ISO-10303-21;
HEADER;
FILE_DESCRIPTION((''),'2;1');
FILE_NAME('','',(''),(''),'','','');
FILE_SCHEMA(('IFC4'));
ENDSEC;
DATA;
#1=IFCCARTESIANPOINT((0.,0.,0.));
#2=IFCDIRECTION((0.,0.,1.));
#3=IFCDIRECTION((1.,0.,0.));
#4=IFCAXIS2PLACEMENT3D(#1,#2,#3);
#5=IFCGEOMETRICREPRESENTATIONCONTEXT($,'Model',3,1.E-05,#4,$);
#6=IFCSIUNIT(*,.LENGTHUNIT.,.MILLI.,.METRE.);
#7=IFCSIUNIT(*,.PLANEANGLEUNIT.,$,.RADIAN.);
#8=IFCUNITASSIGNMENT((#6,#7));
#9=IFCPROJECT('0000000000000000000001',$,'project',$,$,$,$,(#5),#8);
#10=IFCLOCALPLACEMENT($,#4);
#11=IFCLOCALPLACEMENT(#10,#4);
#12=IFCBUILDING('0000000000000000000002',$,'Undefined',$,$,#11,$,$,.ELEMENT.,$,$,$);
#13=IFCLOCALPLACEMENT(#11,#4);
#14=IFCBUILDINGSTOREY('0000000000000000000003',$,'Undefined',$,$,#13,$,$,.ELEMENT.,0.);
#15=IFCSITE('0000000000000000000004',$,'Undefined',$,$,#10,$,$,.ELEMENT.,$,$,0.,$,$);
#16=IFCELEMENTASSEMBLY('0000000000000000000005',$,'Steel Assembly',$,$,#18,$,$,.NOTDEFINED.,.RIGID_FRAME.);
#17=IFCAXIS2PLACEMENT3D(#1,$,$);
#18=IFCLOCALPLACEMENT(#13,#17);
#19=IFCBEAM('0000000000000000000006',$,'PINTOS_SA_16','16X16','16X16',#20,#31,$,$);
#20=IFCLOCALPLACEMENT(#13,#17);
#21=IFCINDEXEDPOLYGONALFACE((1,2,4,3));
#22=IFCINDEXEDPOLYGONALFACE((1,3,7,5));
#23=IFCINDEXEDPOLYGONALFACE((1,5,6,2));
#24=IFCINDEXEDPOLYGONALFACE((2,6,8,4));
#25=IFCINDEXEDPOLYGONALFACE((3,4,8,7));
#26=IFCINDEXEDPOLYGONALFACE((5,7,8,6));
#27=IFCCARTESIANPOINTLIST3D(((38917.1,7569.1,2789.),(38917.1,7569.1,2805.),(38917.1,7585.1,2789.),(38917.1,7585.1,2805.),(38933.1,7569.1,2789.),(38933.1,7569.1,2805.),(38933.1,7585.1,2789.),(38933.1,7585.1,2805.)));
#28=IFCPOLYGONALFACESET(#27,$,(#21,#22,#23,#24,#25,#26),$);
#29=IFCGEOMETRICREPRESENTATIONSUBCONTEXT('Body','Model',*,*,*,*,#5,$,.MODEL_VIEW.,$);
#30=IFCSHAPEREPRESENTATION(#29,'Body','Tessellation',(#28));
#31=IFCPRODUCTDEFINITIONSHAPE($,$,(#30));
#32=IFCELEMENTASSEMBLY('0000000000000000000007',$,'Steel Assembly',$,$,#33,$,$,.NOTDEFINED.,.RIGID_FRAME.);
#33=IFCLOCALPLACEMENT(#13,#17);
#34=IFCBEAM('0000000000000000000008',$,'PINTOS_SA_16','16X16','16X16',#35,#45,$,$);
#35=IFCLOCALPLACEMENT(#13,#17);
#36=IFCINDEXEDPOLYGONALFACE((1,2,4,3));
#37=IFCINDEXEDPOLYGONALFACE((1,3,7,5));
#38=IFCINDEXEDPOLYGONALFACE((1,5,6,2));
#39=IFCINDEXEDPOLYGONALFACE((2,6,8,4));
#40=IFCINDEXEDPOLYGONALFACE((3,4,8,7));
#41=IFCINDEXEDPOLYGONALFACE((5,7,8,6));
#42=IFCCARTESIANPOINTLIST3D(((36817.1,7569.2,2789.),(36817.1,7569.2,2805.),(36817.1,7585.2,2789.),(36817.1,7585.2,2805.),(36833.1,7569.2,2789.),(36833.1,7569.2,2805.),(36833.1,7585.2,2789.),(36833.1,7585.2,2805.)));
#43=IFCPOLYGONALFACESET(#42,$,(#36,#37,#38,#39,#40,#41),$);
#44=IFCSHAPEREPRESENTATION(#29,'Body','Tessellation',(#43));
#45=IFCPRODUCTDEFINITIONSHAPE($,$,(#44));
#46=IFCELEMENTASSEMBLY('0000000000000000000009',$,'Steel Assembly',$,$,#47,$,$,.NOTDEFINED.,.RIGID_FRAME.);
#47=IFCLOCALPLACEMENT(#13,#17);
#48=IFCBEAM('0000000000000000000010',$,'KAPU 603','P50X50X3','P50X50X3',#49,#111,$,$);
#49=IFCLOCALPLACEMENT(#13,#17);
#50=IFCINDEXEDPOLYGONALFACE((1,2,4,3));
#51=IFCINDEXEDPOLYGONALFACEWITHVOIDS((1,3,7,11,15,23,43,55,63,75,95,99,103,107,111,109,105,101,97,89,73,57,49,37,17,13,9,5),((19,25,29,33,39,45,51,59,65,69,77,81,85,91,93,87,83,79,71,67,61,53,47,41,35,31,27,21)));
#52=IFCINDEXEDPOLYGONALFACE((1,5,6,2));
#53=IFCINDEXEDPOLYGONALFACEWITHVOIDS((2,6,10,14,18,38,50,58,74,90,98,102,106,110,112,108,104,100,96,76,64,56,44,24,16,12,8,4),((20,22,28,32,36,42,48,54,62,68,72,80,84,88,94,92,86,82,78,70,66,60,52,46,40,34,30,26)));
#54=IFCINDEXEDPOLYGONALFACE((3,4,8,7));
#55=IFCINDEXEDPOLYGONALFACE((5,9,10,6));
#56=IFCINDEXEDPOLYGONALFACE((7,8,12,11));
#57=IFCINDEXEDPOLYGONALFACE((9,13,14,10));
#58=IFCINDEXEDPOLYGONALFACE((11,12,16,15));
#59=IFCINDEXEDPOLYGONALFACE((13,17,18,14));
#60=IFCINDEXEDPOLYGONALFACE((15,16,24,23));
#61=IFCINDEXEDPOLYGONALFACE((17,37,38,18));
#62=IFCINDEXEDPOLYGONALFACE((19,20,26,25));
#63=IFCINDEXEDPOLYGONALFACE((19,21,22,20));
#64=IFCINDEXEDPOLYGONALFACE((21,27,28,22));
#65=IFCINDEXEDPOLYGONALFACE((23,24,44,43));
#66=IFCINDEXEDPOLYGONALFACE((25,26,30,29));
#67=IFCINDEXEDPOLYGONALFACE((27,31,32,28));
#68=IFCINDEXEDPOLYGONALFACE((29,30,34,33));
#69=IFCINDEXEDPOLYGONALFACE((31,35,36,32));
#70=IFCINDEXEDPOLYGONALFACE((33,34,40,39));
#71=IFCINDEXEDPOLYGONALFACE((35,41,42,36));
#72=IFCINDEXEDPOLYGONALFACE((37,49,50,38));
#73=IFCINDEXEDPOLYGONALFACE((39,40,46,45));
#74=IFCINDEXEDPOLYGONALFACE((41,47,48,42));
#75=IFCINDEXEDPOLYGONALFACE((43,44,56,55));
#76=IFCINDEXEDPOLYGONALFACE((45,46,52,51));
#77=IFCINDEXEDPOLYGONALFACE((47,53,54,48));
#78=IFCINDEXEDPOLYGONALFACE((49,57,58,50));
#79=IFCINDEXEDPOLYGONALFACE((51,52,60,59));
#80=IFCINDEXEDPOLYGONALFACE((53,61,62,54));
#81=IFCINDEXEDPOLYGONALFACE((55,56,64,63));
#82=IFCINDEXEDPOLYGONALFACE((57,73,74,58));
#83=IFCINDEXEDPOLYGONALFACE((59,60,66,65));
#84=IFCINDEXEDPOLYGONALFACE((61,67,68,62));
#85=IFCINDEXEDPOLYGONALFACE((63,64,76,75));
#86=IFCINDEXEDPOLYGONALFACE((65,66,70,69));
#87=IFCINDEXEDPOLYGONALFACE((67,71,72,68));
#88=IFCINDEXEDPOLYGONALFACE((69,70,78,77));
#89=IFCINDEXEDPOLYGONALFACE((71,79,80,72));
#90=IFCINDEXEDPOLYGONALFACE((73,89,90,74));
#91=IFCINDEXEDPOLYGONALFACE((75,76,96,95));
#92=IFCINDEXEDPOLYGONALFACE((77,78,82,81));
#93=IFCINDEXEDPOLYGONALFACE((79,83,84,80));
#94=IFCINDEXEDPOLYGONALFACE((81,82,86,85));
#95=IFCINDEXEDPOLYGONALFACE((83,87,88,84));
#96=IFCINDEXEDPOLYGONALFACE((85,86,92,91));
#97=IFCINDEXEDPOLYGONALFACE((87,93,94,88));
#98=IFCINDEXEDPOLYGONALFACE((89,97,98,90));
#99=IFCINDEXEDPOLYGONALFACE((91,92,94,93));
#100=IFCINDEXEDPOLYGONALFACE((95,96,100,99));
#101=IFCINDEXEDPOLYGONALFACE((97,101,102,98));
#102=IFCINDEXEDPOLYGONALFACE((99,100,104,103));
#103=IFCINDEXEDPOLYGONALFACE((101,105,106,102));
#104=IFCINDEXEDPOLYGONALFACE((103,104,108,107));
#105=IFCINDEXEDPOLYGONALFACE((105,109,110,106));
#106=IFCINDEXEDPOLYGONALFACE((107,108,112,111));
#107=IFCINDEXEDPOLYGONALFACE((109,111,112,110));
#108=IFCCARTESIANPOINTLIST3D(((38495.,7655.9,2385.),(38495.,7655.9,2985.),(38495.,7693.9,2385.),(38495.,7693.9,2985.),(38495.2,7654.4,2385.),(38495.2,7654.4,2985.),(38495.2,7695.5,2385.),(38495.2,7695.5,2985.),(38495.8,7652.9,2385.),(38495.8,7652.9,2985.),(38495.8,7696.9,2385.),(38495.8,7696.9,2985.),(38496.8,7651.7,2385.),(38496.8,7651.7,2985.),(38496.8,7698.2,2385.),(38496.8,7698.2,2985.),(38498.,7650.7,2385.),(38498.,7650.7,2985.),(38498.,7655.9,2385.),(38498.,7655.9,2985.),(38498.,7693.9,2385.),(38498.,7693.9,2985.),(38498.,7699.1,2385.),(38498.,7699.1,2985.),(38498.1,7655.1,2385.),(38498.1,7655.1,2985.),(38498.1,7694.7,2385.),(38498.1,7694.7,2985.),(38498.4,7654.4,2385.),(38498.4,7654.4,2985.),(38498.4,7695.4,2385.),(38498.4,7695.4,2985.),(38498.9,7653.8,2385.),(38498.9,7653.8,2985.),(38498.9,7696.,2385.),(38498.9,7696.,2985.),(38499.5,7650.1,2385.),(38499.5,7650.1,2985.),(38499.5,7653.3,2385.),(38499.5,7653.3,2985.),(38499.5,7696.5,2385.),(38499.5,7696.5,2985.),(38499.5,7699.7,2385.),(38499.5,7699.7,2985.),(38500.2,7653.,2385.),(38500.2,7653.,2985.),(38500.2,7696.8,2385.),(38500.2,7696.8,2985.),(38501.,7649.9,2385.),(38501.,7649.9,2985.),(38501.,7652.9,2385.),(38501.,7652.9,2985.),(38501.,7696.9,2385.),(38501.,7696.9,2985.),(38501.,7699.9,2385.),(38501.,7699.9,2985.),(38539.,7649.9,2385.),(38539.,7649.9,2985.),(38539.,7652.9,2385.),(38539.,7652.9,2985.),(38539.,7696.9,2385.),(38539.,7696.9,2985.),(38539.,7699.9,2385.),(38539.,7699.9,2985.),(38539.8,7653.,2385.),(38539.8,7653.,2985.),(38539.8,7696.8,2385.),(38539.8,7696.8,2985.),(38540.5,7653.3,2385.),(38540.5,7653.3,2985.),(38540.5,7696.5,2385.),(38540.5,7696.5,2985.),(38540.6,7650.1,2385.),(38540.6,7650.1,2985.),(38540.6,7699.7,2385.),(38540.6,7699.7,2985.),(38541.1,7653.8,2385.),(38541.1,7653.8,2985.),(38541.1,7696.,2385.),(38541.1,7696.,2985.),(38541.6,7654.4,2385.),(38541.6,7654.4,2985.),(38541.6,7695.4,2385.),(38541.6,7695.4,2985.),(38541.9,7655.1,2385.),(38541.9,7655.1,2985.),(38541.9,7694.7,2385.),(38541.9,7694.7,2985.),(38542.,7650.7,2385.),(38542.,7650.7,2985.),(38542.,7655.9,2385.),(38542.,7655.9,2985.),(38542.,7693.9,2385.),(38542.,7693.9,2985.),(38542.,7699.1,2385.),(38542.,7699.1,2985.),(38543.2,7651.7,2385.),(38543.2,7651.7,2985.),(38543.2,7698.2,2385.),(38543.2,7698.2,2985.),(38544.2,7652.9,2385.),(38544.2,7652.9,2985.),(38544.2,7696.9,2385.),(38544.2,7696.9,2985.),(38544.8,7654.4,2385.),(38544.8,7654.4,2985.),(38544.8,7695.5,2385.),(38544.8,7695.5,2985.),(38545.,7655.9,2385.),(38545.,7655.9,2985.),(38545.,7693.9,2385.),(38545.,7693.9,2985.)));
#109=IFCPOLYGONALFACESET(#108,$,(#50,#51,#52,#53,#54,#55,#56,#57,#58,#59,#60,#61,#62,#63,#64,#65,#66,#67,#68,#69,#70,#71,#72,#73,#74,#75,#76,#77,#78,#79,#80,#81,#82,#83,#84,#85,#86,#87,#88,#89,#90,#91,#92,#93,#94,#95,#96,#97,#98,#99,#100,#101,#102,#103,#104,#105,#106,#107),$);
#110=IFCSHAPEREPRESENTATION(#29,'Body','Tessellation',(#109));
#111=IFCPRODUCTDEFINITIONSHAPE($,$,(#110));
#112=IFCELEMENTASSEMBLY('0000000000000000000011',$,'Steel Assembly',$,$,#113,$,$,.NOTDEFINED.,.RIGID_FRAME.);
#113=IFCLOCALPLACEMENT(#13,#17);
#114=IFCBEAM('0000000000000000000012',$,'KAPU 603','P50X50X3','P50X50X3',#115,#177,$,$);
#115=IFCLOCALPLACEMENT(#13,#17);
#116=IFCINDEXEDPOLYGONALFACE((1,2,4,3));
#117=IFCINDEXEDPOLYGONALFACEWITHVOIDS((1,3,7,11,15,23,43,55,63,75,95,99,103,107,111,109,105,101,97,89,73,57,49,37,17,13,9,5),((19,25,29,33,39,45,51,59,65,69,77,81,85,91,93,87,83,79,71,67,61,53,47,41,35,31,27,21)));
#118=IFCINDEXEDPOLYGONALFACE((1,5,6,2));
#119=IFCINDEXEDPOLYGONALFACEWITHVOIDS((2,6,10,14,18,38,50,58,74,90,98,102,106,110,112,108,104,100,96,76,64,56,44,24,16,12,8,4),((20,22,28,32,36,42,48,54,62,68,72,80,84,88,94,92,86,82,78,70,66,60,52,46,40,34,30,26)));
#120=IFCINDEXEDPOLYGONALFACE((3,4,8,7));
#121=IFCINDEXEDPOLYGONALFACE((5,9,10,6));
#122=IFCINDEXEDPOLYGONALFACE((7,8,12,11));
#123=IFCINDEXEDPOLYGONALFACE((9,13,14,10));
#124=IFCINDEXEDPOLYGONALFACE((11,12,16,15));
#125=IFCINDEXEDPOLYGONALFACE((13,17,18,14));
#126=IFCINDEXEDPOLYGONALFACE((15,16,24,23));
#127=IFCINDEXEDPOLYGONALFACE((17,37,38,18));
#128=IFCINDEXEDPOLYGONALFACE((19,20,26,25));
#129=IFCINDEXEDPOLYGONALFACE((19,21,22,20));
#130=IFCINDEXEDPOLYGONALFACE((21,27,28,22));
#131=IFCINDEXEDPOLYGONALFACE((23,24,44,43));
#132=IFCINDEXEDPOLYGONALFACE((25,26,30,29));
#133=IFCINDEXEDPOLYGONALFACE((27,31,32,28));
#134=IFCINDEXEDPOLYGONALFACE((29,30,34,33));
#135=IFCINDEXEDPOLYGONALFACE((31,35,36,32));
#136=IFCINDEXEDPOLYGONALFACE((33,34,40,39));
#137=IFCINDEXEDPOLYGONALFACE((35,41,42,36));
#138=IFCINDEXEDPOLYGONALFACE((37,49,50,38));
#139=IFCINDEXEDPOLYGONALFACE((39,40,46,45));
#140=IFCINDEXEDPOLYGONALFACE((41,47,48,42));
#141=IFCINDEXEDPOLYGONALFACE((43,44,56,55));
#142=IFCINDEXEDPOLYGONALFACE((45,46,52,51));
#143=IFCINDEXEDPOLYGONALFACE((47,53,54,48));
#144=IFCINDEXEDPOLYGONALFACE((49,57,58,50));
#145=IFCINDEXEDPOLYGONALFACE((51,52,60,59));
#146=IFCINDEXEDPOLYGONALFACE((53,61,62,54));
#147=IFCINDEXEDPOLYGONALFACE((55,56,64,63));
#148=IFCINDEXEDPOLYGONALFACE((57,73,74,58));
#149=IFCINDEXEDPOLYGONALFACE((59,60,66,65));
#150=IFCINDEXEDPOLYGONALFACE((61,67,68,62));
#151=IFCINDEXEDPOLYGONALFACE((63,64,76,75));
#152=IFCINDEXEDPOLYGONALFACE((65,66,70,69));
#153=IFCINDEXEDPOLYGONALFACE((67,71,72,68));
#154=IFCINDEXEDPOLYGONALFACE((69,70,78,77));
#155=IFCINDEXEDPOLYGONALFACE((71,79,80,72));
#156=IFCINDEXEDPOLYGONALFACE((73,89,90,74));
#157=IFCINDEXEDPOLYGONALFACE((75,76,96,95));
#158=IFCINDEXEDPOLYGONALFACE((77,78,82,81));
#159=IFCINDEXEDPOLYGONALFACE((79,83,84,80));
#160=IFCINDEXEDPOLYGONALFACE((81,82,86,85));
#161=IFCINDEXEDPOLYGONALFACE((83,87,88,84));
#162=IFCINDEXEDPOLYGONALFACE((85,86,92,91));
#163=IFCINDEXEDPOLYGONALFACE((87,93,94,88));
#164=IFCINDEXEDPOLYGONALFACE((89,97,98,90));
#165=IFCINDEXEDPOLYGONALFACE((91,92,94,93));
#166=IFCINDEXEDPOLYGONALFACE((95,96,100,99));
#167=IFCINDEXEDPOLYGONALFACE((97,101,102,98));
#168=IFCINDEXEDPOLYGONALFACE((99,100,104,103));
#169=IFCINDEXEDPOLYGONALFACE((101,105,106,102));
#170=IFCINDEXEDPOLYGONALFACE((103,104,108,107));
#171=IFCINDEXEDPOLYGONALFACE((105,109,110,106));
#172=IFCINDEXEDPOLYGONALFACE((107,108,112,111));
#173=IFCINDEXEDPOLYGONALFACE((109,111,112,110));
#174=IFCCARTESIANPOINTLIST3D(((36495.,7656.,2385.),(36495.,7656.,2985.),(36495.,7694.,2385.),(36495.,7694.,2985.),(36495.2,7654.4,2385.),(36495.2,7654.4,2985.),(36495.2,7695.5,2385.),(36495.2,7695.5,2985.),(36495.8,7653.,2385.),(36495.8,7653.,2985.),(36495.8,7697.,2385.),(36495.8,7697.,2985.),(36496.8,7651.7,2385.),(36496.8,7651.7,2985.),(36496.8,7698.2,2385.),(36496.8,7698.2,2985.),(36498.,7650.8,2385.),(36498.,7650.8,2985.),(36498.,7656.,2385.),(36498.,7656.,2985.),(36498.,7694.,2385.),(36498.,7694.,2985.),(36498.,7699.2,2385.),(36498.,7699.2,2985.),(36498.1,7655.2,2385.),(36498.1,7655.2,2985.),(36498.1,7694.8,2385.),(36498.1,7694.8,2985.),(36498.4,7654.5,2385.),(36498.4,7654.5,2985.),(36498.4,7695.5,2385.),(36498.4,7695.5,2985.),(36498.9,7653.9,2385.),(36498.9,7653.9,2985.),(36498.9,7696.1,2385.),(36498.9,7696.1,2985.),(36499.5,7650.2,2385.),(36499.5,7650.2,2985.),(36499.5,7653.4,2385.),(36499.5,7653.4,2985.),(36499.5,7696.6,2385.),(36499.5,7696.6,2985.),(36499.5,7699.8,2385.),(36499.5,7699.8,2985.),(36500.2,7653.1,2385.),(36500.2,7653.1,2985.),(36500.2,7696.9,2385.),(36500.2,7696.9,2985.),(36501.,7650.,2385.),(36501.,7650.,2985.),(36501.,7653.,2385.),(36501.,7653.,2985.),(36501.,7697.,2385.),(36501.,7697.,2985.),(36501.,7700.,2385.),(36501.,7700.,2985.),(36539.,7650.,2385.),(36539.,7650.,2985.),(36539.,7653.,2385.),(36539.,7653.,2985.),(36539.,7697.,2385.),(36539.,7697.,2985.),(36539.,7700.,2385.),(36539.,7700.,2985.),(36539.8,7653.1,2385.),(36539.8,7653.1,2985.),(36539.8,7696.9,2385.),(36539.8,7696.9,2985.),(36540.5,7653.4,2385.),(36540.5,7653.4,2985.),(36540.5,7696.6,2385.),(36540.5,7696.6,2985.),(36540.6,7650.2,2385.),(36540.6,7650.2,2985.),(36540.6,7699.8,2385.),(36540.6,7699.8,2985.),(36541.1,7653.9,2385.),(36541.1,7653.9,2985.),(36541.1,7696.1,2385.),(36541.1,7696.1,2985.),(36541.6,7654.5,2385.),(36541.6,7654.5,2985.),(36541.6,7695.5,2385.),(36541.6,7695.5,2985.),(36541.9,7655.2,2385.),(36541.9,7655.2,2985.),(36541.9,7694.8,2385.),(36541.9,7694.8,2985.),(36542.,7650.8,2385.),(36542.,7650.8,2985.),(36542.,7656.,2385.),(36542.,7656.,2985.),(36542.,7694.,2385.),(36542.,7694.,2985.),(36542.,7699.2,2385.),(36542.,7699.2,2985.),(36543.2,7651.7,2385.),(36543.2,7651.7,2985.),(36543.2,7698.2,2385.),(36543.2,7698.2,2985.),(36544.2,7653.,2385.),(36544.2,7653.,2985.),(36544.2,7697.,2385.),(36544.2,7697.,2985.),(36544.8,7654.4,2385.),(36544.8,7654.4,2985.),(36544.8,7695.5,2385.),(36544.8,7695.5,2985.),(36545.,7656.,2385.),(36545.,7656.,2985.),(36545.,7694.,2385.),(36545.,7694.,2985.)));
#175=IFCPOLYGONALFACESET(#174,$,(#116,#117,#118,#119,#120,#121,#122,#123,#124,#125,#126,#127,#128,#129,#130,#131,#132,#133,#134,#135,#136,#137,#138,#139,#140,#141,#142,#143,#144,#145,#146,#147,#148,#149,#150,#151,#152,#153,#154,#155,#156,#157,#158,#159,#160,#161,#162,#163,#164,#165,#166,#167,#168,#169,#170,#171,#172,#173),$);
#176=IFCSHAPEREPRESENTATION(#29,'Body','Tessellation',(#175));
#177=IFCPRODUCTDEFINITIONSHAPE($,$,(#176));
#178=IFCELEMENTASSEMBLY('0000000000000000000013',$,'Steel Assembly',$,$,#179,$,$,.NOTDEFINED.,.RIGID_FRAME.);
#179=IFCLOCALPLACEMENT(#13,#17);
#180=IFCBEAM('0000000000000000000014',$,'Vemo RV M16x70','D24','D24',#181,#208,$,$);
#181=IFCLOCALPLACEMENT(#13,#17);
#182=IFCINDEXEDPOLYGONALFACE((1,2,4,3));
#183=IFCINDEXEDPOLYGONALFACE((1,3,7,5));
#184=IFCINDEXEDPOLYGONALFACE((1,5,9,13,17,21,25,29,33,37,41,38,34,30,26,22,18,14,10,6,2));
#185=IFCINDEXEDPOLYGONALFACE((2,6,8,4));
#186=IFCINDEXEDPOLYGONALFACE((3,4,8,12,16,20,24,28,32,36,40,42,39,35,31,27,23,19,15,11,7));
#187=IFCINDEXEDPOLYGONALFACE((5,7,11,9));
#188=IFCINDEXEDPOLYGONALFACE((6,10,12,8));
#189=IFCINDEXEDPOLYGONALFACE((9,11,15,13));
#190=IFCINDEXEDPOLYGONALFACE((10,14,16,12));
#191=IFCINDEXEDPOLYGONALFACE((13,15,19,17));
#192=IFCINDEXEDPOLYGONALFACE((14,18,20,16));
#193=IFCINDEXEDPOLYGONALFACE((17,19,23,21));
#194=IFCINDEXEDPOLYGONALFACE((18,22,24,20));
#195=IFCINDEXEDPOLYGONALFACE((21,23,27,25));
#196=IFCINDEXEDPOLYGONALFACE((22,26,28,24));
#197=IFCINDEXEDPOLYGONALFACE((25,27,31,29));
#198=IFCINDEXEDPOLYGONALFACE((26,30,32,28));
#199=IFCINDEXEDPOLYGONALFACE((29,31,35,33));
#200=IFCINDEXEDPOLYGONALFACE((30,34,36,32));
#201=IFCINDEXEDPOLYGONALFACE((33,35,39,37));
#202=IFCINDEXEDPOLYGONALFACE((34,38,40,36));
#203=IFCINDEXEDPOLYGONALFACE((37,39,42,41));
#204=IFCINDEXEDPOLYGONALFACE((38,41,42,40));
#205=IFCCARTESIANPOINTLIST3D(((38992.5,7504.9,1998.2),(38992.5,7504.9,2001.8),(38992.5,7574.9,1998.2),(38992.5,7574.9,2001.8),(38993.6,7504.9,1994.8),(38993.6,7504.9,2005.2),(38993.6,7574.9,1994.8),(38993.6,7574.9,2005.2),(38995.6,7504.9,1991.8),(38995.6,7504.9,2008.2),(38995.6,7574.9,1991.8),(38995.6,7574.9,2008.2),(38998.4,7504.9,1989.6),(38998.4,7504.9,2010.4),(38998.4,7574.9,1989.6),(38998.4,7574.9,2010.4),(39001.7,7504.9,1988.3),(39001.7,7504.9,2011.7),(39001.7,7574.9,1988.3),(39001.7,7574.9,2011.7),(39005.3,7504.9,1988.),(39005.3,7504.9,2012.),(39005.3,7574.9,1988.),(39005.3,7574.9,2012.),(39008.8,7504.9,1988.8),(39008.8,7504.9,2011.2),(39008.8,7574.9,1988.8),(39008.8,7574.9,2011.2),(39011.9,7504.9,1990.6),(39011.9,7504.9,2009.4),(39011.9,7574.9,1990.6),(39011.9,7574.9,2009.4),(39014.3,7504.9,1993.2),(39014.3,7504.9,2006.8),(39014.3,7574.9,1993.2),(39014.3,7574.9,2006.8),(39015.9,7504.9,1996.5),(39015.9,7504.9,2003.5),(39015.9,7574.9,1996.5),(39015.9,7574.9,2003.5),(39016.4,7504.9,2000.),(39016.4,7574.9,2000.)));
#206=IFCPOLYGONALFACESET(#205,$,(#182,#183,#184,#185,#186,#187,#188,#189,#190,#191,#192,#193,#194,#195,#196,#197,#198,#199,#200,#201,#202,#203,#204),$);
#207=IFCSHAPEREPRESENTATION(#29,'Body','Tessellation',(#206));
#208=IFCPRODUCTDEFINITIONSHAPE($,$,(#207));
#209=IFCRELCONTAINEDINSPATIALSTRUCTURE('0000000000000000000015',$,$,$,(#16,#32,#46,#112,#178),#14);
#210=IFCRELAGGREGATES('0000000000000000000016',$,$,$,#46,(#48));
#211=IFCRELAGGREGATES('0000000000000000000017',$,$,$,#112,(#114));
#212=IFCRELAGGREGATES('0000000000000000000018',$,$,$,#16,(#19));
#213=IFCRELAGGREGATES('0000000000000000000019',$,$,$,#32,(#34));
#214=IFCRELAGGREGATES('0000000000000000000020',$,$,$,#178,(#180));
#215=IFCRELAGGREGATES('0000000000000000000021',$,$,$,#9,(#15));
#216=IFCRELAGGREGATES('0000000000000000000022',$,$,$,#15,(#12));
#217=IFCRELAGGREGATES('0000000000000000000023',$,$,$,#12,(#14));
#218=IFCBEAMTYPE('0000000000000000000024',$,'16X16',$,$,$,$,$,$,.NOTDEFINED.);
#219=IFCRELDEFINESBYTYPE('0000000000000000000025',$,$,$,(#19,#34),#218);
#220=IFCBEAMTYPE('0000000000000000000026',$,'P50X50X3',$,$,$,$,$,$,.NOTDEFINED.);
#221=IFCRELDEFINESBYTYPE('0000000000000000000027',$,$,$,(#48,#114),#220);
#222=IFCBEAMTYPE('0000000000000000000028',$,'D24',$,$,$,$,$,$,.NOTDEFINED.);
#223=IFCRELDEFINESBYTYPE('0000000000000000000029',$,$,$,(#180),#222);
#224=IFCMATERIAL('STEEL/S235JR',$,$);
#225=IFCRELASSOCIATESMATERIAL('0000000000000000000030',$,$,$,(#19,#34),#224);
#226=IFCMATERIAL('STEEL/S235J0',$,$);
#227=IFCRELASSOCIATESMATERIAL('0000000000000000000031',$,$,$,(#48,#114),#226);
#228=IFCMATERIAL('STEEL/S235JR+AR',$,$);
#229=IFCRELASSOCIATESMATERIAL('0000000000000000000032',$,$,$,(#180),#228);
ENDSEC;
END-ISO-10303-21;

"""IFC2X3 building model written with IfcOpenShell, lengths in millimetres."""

from ifc_helpers import new_model, si_unit, frame, origin_with_axes, origin_2d_with_axis, place, context, subcontext, project, spatial, rectangle, hollow_rectangle, circle, extrude, material, type_object, element, aggregate, save


model = new_model("IFC2X3")

# Units and contexts
model_context = context("Model", 3, precision=1e-05, world=origin_with_axes())
body_context = subcontext(model_context, "Body", "Model", "MODEL_VIEW")
ifc_project = project(units=[si_unit("LENGTHUNIT", "METRE", prefix="MILLI"), si_unit("PLANEANGLEUNIT", "RADIAN")], contexts=[model_context])

# Site, building, storey
site_placement = place(None, origin_with_axes())
site = spatial("IfcSite", under=ifc_project, at=site_placement, Name="Undefined", CompositionType="ELEMENT", RefElevation=0.0)
building_placement = place(site_placement, origin_with_axes())
building = spatial("IfcBuilding", under=site, at=building_placement, Name="Undefined", CompositionType="ELEMENT")
storey_placement = place(building_placement, origin_with_axes())
storey = spatial("IfcBuildingStorey", under=building, at=storey_placement, Name="Undefined", CompositionType="ELEMENT", Elevation=0.0)

# Element assemblies, beams
assembly_1_placement = place(storey_placement, origin_with_axes())
assembly_1 = element("IfcElementAssembly", 1, at=assembly_1_placement, inside=storey, Name="Steel Assembly", AssemblyPlace="NOTDEFINED", PredefinedType="RIGID_FRAME")
ifc_material_1 = material(Name="STEEL/S235JR")
beam_type_1 = type_object("IfcBeamType", Name="16X16", PredefinedType="NOTDEFINED")
beam_1_placement = place(assembly_1_placement, frame((38933.1, 7577.1, 2797.0), z_axis=(0.0, 0.0, 1.0), x_axis=(-1.0, 0.00003, 0.0)))
beam_1 = element("IfcBeam", 2, at=beam_1_placement, type_object=beam_type_1, material=ifc_material_1, Name="PINTOS_SA_16", Description="16X16", ObjectType="16X16", context=body_context, shape_type="SweptSolid", body=[
    extrude(rectangle(XDim=16.0, YDim=16.0, at=origin_2d_with_axis()), frame((16.0, 0.0, 0.0), z_axis=(-1.0, 0.0, 0.0), x_axis=(0.0, -1.0, 0.0)), (0.0, 0.0, 1.0), 16.0),
])
assembly_2_placement = place(storey_placement, origin_with_axes())
assembly_2 = element("IfcElementAssembly", 3, at=assembly_2_placement, inside=storey, Name="Steel Assembly", AssemblyPlace="NOTDEFINED", PredefinedType="RIGID_FRAME")
beam_2_placement = place(assembly_2_placement, frame((36817.1, 7577.2, 2797.0), z_axis=(0.0, 0.0, 1.0), x_axis=(1.0, -0.00003, 0.0)))
beam_2 = element("IfcBeam", 4, at=beam_2_placement, type_object=beam_type_1, material=ifc_material_1, Name="PINTOS_SA_16", Description="16X16", ObjectType="16X16", context=body_context, shape_type="SweptSolid", body=[
    extrude(rectangle(XDim=16.0, YDim=16.0, at=origin_2d_with_axis()), frame((16.0, 0.0, 0.0), z_axis=(-1.0, 0.0, 0.0), x_axis=(0.0, -1.0, 0.0)), (0.0, 0.0, 1.0), 16.0),
])
assembly_3_placement = place(storey_placement, origin_with_axes())
assembly_3 = element("IfcElementAssembly", 5, at=assembly_3_placement, inside=storey, Name="Steel Assembly", AssemblyPlace="NOTDEFINED", PredefinedType="RIGID_FRAME")
ifc_material_2 = material(Name="STEEL/S235J0")
beam_type_2 = type_object("IfcBeamType", Name="P50X50X3", PredefinedType="NOTDEFINED")
beam_3_placement = place(assembly_3_placement, frame((38520.0, 7674.9, 2985.0), z_axis=(1.0, -0.00003, 0.0), x_axis=(0.0, 0.0, -1.0)))
beam_3 = element("IfcBeam", 6, at=beam_3_placement, type_object=beam_type_2, material=ifc_material_2, Name="KAPU 603", Description="P50X50X3", ObjectType="P50X50X3", context=body_context, shape_type="SweptSolid", body=[
    extrude(hollow_rectangle(XDim=50.0, YDim=50.0, WallThickness=3.0, InnerFilletRadius=3.0, OuterFilletRadius=6.0, at=origin_2d_with_axis()), frame((600.0, 0.0, 0.0), z_axis=(-1.0, 0.0, 0.0), x_axis=(0.0, -1.0, 0.0)), (0.0, 0.0, 1.0), 600.0),
])
aggregate(assembly_3, [beam_3])
assembly_4_placement = place(storey_placement, origin_with_axes())
assembly_4 = element("IfcElementAssembly", 7, at=assembly_4_placement, inside=storey, Name="Steel Assembly", AssemblyPlace="NOTDEFINED", PredefinedType="RIGID_FRAME")
beam_4_placement = place(assembly_4_placement, frame((36520.0, 7675.0, 2985.0), z_axis=(1.0, -0.00003, 0.0), x_axis=(0.0, 0.0, -1.0)))
beam_4 = element("IfcBeam", 8, at=beam_4_placement, type_object=beam_type_2, material=ifc_material_2, Name="KAPU 603", Description="P50X50X3", ObjectType="P50X50X3", context=body_context, shape_type="SweptSolid", body=[
    extrude(hollow_rectangle(XDim=50.0, YDim=50.0, WallThickness=3.0, InnerFilletRadius=3.0, OuterFilletRadius=6.0, at=origin_2d_with_axis()), frame((600.0, 0.0, 0.0), z_axis=(-1.0, 0.0, 0.0), x_axis=(0.0, -1.0, 0.0)), (0.0, 0.0, 1.0), 600.0),
])
aggregate(assembly_4, [beam_4])
assembly_5_placement = place(storey_placement, origin_with_axes())
assembly_5 = element("IfcElementAssembly", 9, at=assembly_5_placement, inside=storey, Name="Steel Assembly", AssemblyPlace="NOTDEFINED", PredefinedType="RIGID_FRAME")
ifc_material_3 = material(Name="STEEL/S235JR+AR")
beam_type_3 = type_object("IfcBeamType", Name="D24", PredefinedType="NOTDEFINED")
beam_5_placement = place(assembly_5_placement, frame((39004.4, 7504.9, 2000.0), z_axis=(0.0, 0.0, 1.0), x_axis=(0.00003, 1.0, 0.0)))
beam_5 = element("IfcBeam", 10, at=beam_5_placement, type_object=beam_type_3, material=ifc_material_3, Name="Vemo RV M16x70", Description="D24", ObjectType="D24", context=body_context, shape_type="SweptSolid", body=[
    extrude(circle(Radius=12.0, at=origin_2d_with_axis()), frame((70.0, 0.0, 0.0), z_axis=(-1.0, 0.0, 0.0), x_axis=(0.0, -1.0, 0.0)), (0.0, 0.0, 1.0), 70.0),
])

aggregate(assembly_1, [beam_1])
aggregate(assembly_2, [beam_2])

aggregate(assembly_5, [beam_5])

save(model, "model.ifc")
